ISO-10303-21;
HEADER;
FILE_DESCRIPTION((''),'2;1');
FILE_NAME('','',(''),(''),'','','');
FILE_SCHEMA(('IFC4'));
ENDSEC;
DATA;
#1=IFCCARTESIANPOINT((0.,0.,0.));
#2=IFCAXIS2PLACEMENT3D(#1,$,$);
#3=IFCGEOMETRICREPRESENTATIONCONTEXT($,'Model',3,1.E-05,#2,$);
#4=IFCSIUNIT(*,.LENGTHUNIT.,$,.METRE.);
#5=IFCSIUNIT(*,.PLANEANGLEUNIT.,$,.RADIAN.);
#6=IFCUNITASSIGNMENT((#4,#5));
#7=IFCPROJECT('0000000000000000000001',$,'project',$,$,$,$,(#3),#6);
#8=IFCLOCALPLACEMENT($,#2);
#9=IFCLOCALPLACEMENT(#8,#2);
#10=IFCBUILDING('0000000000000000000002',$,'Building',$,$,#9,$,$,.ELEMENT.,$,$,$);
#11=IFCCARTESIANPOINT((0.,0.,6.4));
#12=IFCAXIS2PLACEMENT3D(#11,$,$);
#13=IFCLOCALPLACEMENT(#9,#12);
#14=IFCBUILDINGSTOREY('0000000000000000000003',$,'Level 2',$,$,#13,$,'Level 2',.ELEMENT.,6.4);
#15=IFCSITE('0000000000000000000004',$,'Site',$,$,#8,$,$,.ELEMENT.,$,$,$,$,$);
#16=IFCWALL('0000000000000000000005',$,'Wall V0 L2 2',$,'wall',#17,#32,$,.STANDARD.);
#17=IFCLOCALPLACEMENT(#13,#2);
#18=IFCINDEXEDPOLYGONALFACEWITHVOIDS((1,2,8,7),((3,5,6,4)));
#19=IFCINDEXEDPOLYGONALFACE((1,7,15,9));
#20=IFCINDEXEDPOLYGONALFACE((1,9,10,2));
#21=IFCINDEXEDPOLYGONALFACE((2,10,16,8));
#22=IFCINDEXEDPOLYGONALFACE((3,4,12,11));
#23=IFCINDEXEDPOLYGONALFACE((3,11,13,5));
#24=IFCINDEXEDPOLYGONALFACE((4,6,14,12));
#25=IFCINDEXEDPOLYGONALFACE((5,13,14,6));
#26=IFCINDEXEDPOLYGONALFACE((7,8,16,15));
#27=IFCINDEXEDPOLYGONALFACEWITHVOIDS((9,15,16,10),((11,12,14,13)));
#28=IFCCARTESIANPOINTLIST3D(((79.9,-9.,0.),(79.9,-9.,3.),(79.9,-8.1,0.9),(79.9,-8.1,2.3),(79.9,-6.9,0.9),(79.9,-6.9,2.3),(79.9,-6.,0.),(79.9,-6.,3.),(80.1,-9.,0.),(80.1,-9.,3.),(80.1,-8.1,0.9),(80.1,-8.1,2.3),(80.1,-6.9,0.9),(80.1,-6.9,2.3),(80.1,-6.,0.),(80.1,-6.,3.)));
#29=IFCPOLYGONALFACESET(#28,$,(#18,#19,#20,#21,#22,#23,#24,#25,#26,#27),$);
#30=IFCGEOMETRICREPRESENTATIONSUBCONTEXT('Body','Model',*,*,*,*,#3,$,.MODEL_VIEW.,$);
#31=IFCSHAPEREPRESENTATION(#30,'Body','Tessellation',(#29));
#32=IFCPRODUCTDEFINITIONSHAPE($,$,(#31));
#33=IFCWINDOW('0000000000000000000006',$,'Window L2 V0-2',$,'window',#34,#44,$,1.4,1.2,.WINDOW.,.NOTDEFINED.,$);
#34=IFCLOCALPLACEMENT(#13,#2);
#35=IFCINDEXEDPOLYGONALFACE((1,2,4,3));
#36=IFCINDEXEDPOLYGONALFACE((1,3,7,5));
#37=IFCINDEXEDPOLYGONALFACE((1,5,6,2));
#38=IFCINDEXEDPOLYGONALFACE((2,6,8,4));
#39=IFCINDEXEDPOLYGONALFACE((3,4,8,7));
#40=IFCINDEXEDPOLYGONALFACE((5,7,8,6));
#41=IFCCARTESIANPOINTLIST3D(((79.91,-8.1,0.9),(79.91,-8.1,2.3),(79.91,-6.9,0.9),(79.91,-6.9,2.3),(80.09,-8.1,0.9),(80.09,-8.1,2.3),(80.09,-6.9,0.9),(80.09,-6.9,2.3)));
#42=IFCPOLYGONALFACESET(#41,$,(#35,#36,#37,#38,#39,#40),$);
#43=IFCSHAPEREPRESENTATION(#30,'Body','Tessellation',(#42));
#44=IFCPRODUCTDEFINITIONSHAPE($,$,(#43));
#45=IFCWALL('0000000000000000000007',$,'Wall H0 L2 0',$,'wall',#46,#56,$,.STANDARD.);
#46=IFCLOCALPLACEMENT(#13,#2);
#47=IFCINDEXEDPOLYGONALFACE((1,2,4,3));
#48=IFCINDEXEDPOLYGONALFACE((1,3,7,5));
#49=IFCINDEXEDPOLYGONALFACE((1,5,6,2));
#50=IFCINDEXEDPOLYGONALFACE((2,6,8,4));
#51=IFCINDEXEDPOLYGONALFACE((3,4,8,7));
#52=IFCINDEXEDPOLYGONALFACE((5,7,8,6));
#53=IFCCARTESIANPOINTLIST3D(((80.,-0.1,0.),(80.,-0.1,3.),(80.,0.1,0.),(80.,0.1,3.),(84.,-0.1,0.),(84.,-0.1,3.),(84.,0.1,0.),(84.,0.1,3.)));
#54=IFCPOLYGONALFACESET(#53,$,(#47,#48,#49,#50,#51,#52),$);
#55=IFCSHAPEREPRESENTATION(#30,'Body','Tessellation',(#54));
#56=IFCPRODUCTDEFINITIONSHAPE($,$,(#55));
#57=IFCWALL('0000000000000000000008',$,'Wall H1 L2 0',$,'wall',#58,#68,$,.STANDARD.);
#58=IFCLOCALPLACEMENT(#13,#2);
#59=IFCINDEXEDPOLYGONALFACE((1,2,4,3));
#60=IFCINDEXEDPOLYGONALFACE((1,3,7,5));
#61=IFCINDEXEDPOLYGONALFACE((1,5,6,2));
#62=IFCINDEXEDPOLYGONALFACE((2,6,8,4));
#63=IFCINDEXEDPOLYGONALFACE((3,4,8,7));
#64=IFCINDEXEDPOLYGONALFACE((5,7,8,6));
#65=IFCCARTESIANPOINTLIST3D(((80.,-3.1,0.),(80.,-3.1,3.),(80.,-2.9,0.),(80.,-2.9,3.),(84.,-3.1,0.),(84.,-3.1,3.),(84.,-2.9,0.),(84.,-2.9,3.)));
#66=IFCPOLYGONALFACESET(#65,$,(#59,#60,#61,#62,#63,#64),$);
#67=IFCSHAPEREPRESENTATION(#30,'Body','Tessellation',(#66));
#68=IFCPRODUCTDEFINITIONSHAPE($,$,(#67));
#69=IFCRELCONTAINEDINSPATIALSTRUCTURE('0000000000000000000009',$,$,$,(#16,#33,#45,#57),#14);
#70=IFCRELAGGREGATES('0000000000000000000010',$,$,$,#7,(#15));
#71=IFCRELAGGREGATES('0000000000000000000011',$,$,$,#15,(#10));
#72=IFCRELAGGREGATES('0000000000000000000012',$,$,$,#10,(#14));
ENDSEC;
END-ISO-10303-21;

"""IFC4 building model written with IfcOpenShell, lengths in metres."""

from ifc_helpers import new_model, si_unit, frame, frame_2d, origin, origin_2d, place, context, subcontext, project, spatial, rectangle, extrude, element, fill, save


model = new_model("IFC4")

# Units and contexts
model_context = context("Model", 3, precision=1e-05, world=origin())
body_context = subcontext(model_context, "Body", "Model", "MODEL_VIEW")
ifc_project = project(units=[si_unit("LENGTHUNIT", "METRE"), si_unit("PLANEANGLEUNIT", "RADIAN")], contexts=[model_context])

# Site, building, storey
site_placement = place(None, origin())
site = spatial("IfcSite", under=ifc_project, at=site_placement, Name="Site", CompositionType="ELEMENT")
building_placement = place(site_placement, origin())
building = spatial("IfcBuilding", under=site, at=building_placement, Name="Building", CompositionType="ELEMENT")
storey_placement = place(building_placement, frame((0.0, 0.0, 6.4)))
storey = spatial("IfcBuildingStorey", under=building, at=storey_placement, Name="Level 2", LongName="Level 2", CompositionType="ELEMENT", Elevation=6.4)

# Wall, opening, window
wall_1_placement = place(storey_placement, frame((80.0, -6.0, 0.0), z_axis=(0.0, 0.0, 1.0), x_axis=(0.0, -1.0, 0.0)))
wall_1 = element("IfcWall", 1, at=wall_1_placement, inside=storey, Name="Wall V0 L2 2", ObjectType="wall", PredefinedType="STANDARD", context=body_context, shape_type="SweptSolid", body=[
    extrude(rectangle(XDim=3.0, YDim=0.2, at=frame_2d((1.5, 0.0))), origin(), (0.0, 0.0, 1.0), 3.0),
])
opening_1_placement = place(storey_placement, frame((80.0, -7.5, 0.9), z_axis=(0.0, 0.0, 1.0), x_axis=(0.0, -1.0, 0.0)))
opening_1 = element("IfcOpeningElement", 2, at=opening_1_placement, cuts=wall_1, ObjectType="Opening", PredefinedType="OPENING", context=body_context, shape_type="SweptSolid", body=[
    extrude(rectangle(XDim=1.2, YDim=0.22, at=origin_2d()), origin(), (0.0, 0.0, 1.0), 1.4),
])
window_1_placement = place(storey_placement, frame((80.0, -7.5, 0.9), z_axis=(0.0, 0.0, 1.0), x_axis=(0.0, -1.0, 0.0)))
window_1 = element("IfcWindow", 3, at=window_1_placement, inside=storey, Name="Window L2 V0-2", ObjectType="window", OverallHeight=1.4, OverallWidth=1.2, PartitioningType="NOTDEFINED", PredefinedType="WINDOW", context=body_context, shape_type="SweptSolid", body=[
    extrude(rectangle(XDim=1.2, YDim=0.18, at=origin_2d()), origin(), (0.0, 0.0, 1.0), 1.4),
])
fill(opening_1, window_1)

# Walls
for number, where, z_axis, x_axis, name in (
    (4, (80.0, 0.0, 0.0), (0.0, 0.0, 1.0), (1.0, 0.0, 0.0), "Wall H0 L2 0"),
    (5, (80.0, -3.0, 0.0), (0.0, 0.0, 1.0), (1.0, 0.0, 0.0), "Wall H1 L2 0"),
):
    element("IfcWall", number, at=place(storey_placement, frame(where, z_axis=z_axis, x_axis=x_axis)), inside=storey, Name=name, ObjectType="wall", PredefinedType="STANDARD", context=body_context, shape_type="SweptSolid", body=[
        extrude(rectangle(XDim=4.0, YDim=0.2, at=frame_2d((2.0, 0.0))), origin(), (0.0, 0.0, 1.0), 3.0),
    ])

save(model, "model.ifc")
